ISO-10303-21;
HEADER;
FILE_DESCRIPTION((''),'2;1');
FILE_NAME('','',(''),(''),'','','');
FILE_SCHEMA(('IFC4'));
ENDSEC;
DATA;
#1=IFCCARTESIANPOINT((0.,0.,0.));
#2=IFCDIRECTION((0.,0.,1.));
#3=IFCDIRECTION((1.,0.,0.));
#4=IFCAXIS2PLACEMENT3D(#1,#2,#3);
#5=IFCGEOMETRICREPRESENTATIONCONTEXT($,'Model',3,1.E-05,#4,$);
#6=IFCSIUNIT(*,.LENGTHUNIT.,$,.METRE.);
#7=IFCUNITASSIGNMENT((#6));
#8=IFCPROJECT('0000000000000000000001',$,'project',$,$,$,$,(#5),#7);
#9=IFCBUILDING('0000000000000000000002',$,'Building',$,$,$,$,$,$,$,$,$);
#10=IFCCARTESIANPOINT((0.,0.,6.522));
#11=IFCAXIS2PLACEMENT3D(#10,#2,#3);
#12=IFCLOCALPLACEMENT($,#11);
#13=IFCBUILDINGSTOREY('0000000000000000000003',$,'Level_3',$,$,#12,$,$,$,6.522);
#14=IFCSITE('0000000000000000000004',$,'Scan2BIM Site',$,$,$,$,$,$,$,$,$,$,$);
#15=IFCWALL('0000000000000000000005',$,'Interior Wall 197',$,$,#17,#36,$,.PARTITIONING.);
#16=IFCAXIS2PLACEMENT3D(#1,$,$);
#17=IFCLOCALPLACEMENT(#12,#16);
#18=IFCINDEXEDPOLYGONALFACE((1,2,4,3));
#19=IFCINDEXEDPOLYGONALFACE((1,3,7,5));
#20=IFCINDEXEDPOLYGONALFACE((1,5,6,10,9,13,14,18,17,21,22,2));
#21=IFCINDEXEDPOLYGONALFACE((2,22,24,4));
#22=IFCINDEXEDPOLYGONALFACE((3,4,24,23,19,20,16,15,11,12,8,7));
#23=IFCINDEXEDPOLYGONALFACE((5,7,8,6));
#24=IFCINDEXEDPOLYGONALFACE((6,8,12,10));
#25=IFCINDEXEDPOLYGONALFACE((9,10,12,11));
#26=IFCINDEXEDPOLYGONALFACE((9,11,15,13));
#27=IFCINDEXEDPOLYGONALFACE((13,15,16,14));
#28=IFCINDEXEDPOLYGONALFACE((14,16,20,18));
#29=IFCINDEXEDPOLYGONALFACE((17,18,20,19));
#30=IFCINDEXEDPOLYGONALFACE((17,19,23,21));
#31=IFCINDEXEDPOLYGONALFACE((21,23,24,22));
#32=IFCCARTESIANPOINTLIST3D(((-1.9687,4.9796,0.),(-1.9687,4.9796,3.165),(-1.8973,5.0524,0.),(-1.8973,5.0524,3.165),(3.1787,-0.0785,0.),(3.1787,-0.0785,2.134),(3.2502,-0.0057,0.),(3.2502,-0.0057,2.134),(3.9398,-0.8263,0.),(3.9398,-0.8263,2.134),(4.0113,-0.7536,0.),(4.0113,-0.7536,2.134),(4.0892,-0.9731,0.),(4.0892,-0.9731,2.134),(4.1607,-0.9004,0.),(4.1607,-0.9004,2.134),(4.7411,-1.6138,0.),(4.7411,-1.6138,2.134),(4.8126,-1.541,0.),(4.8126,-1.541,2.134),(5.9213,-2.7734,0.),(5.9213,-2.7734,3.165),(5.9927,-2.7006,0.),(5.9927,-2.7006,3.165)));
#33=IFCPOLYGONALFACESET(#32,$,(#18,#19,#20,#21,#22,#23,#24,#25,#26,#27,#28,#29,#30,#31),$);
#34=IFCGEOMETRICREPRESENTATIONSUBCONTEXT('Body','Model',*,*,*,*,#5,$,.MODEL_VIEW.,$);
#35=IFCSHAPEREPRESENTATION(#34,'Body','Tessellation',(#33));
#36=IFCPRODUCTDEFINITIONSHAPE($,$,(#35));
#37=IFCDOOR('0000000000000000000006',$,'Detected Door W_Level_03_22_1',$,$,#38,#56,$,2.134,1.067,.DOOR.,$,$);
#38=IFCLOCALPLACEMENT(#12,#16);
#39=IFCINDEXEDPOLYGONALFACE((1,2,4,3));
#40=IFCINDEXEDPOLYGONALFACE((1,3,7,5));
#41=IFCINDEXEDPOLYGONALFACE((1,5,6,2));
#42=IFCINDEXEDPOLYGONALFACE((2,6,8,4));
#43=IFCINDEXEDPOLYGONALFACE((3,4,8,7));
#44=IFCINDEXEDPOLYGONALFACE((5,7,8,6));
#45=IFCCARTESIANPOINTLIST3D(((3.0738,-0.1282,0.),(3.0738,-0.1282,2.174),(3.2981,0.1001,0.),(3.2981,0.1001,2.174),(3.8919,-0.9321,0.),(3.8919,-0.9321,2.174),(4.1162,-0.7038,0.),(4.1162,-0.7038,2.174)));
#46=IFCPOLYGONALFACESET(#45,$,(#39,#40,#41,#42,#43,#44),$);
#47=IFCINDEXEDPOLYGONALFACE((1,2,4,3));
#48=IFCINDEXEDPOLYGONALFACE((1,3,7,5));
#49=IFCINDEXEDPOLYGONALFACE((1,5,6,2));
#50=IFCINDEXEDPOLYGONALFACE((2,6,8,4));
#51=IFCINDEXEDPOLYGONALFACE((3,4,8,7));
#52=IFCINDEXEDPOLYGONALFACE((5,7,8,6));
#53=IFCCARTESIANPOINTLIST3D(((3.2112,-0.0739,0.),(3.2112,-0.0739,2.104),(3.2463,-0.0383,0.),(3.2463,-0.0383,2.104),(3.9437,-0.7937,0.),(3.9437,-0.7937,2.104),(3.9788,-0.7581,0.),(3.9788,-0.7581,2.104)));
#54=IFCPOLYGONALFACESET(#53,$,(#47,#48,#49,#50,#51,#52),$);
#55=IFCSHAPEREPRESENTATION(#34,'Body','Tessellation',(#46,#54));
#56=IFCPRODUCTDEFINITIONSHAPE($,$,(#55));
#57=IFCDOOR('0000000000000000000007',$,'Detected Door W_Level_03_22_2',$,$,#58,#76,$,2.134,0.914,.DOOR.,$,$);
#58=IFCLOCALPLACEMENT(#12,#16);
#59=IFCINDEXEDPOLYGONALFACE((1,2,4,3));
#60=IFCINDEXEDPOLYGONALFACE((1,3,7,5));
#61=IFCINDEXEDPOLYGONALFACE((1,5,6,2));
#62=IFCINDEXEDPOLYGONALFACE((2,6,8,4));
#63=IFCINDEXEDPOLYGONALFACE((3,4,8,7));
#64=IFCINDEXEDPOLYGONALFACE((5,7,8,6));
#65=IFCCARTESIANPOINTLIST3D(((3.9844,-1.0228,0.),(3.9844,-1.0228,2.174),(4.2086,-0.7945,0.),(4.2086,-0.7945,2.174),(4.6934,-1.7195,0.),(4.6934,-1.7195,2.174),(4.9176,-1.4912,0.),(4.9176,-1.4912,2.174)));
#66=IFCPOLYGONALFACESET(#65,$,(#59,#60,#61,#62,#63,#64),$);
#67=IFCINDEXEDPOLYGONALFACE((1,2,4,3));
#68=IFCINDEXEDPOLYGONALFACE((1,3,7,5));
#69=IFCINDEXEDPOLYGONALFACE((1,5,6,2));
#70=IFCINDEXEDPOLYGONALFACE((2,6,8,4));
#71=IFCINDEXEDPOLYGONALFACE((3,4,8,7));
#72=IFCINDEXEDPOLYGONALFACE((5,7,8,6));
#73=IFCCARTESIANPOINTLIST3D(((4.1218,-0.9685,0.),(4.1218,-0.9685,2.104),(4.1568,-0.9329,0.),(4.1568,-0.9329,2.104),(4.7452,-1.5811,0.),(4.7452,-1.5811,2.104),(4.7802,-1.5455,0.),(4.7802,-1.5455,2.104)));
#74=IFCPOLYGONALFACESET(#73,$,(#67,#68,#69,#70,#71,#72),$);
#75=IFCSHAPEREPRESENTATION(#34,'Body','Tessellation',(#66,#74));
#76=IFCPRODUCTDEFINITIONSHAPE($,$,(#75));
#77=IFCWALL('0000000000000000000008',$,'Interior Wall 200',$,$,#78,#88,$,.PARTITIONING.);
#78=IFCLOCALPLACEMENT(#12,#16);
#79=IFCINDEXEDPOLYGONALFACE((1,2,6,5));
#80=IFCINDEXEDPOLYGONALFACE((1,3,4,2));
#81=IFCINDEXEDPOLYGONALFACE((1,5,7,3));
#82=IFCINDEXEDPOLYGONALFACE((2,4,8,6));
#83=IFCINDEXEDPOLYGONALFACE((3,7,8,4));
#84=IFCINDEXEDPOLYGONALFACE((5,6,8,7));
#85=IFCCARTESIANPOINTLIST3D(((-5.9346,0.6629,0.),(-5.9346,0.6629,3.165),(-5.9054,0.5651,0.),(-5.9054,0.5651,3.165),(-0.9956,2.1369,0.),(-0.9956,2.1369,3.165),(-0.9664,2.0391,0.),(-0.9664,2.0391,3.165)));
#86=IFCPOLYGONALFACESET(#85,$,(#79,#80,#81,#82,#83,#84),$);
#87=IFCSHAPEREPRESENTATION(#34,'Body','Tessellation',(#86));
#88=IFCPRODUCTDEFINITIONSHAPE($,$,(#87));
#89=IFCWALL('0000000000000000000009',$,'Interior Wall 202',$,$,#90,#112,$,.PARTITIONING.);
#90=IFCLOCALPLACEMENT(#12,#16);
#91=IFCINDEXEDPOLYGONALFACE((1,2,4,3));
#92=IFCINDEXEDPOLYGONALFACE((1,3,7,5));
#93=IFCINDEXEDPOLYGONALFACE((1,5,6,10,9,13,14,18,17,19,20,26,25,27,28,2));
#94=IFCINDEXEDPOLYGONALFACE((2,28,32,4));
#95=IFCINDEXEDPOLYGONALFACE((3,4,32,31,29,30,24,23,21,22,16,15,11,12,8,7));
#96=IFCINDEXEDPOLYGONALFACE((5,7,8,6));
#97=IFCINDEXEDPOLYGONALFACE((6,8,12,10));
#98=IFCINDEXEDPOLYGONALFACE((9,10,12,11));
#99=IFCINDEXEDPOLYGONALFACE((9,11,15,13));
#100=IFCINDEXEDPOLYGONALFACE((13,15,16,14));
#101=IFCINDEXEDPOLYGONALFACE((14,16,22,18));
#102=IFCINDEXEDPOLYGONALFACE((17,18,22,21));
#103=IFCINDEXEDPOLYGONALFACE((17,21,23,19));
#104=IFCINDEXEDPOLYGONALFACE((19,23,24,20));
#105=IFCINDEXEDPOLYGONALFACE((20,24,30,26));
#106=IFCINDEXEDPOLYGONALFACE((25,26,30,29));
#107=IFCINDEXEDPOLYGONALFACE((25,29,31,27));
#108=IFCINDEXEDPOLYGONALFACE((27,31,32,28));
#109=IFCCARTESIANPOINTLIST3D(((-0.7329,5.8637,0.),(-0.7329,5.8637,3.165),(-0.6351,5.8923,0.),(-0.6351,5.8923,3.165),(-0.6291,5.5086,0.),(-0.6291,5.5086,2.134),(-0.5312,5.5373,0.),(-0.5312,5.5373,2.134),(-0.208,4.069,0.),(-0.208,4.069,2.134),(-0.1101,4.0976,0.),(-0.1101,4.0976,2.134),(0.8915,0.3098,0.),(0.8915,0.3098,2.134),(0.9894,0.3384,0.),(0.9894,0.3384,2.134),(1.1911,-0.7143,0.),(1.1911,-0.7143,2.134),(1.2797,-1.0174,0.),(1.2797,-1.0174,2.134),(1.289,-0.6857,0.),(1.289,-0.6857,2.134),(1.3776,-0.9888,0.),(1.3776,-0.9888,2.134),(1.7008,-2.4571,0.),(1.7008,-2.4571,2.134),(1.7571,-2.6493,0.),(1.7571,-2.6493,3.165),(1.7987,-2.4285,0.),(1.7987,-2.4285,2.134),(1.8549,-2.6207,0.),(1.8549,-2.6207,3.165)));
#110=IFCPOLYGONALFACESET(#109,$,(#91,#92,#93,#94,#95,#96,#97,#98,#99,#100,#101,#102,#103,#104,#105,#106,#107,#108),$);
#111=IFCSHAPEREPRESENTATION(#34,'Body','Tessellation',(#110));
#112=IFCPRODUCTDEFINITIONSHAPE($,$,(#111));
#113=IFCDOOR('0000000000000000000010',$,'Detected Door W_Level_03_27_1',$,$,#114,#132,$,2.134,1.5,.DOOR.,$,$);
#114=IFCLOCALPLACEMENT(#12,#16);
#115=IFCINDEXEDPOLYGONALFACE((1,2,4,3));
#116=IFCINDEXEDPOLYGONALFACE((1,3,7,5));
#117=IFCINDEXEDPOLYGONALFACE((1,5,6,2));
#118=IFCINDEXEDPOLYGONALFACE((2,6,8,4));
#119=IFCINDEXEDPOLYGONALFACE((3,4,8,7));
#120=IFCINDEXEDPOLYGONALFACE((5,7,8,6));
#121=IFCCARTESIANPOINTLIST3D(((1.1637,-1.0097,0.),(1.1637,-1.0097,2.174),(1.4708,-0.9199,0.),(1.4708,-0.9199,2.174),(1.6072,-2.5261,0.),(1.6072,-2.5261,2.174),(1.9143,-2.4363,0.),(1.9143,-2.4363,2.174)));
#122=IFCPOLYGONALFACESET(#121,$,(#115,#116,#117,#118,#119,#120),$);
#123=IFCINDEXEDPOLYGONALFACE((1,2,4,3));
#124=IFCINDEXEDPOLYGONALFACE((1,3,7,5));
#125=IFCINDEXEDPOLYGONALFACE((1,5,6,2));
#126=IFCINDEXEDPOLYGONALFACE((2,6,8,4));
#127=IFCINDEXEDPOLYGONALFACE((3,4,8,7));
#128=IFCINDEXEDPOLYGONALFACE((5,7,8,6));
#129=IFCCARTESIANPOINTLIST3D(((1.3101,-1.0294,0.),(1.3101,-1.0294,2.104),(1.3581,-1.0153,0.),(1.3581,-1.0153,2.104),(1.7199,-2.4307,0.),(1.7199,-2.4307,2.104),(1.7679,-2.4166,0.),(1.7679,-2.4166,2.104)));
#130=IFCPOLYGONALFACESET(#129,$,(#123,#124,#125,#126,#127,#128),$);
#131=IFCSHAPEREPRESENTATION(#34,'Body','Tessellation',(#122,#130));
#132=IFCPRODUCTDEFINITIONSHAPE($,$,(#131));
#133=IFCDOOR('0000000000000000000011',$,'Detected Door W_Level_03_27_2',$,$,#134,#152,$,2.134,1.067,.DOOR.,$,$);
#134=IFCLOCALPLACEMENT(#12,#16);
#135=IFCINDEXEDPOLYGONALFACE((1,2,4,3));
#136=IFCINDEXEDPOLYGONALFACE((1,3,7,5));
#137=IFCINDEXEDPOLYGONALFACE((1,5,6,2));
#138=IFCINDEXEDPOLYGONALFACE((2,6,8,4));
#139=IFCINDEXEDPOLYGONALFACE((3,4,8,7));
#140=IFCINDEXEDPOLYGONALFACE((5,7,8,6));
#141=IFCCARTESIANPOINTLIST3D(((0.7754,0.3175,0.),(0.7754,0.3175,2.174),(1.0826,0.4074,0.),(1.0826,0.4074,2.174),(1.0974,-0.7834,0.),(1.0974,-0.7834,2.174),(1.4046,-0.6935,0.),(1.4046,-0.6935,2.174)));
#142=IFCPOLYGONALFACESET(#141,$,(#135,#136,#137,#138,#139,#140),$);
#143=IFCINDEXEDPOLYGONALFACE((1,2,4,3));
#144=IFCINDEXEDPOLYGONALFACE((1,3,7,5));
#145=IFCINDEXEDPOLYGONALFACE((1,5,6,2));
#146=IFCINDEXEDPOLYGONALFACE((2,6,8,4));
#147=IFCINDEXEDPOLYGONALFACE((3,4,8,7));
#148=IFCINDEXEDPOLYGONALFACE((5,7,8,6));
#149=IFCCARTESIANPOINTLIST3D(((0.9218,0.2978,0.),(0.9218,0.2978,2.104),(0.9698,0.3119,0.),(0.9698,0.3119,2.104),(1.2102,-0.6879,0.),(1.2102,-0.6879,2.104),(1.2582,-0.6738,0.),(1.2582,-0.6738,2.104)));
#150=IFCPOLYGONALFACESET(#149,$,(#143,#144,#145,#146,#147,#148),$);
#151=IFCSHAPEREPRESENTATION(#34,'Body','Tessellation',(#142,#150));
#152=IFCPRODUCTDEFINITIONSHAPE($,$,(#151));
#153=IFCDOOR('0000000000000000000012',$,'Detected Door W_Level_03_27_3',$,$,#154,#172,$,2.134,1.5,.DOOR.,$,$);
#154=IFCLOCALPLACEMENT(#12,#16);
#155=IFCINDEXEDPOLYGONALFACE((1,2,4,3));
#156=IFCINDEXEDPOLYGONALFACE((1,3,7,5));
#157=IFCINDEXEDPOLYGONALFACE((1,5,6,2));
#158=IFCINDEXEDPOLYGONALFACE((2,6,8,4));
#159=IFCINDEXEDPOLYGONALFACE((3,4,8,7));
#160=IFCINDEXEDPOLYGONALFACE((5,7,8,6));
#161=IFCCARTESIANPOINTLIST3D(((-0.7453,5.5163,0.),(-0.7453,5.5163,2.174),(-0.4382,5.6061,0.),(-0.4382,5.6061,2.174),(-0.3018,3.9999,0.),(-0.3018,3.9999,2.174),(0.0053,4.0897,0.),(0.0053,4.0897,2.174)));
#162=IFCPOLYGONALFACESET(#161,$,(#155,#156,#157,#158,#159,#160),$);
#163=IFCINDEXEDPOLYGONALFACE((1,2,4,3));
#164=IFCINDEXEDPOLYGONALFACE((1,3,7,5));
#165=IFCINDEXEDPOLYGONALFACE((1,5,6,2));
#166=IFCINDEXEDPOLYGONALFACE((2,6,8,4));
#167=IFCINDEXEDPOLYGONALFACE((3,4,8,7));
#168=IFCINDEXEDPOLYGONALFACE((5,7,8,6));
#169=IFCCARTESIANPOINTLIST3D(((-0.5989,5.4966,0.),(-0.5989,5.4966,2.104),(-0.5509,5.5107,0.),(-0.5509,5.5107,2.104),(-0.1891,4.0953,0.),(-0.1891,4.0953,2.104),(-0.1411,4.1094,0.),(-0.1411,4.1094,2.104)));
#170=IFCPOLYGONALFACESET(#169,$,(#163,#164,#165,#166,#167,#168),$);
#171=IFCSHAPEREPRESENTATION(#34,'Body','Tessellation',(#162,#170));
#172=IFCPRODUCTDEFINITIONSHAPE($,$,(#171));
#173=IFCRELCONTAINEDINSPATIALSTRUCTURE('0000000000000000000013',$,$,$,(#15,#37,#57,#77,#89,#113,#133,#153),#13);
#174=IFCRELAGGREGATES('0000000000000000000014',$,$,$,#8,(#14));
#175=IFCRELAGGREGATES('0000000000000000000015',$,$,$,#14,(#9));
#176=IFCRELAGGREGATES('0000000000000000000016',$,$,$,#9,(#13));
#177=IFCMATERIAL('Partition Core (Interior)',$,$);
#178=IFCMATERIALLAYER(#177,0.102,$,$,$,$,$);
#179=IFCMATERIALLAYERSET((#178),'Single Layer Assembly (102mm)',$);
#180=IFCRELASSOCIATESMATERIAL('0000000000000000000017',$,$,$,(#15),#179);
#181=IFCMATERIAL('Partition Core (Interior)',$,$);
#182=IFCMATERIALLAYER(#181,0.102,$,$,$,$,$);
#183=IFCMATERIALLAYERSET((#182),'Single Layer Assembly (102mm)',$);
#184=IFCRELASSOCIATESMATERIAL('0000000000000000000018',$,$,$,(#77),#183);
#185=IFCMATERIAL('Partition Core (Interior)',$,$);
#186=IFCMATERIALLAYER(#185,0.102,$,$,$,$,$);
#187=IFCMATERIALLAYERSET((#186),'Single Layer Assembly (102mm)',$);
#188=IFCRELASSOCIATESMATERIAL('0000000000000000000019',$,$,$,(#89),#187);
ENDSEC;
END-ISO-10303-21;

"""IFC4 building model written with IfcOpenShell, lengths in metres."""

from ifc_helpers import new_model, si_unit, frame, origin, origin_with_axes, place, context, subcontext, project, spatial, rectangle, extrude, material, layer, layer_set, element, fill, save


model = new_model("IFC4")

# Units and contexts
model_context = context("Model", 3, precision=1e-05, world=origin_with_axes())
body_context = subcontext(model_context, "Body", "Model", "MODEL_VIEW")
ifc_project = project(units=[si_unit("LENGTHUNIT", "METRE")], contexts=[model_context])

# Site, building, storey
site = spatial("IfcSite", under=ifc_project, Name="Scan2BIM Site")
building = spatial("IfcBuilding", under=site, Name="Building")
storey_placement = place(None, frame((0.0, 0.0, 6.522), z_axis=(0.0, 0.0, 1.0), x_axis=(1.0, 0.0, 0.0)))
storey = spatial("IfcBuildingStorey", under=building, at=storey_placement, Name="Level_3", Elevation=6.522)

# Wall, openings, doors
ifc_material_1 = material(Name="Partition Core (Interior)")
ifc_layer_1 = layer(ifc_material_1, 0.102)
ifc_layer_set_1 = layer_set([ifc_layer_1], Name="Single Layer Assembly (102mm)")
wall_1_placement = place(storey_placement, frame((2.012, 1.1395, 0.0), z_axis=(0.0, 0.0, 1.0), x_axis=(0.713272, -0.700887, 0.0)))
wall_1 = element("IfcWall", 1, at=wall_1_placement, inside=storey, material=ifc_layer_set_1, Name="Interior Wall 197", PredefinedType="PARTITIONING", context=body_context, shape_type="SweptSolid", body=[
    extrude(rectangle(XDim=11.0617, YDim=0.102), origin(), (0.0, 0.0, 1.0), 3.165),
])
opening_1_placement = place(None, frame((3.595, -0.416, 6.522), z_axis=(0.0, 0.0, 1.0), x_axis=(0.713272, -0.700887, 0.0)))
opening_1 = element("IfcOpeningElement", 2, at=opening_1_placement, cuts=wall_1, PredefinedType="OPENING", context=body_context, shape_type="SweptSolid", body=[
    extrude(rectangle(XDim=1.067, YDim=0.202), origin(), (0.0, 0.0, 1.0), 2.134),
])
opening_2_placement = place(None, frame((4.451, -1.257, 6.522), z_axis=(0.0, 0.0, 1.0), x_axis=(0.713272, -0.700887, 0.0)))
opening_2 = element("IfcOpeningElement", 3, at=opening_2_placement, cuts=wall_1, PredefinedType="OPENING", context=body_context, shape_type="SweptSolid", body=[
    extrude(rectangle(XDim=0.914, YDim=0.202), origin(), (0.0, 0.0, 1.0), 2.134),
])
door_1_placement = place(opening_1_placement, frame((0.0, 0.0, 0.0), z_axis=(0.0, 0.0, 1.0), x_axis=(1.0, 0.0, 0.0)))
door_1 = element("IfcDoor", 4, at=door_1_placement, inside=storey, Name="Detected Door W_Level_03_22_1", OverallHeight=2.134, OverallWidth=1.067, PredefinedType="DOOR", context=body_context, shape_type="SweptSolid", body=[
    extrude(rectangle(XDim=1.147, YDim=0.32), origin(), (0.0, 0.0, 1.0), 2.174),
    extrude(rectangle(XDim=1.027, YDim=0.05), origin(), (0.0, 0.0, 1.0), 2.104),
])
fill(opening_1, door_1)
door_2_placement = place(opening_2_placement, frame((0.0, 0.0, 0.0), z_axis=(0.0, 0.0, 1.0), x_axis=(1.0, 0.0, 0.0)))
door_2 = element("IfcDoor", 5, at=door_2_placement, inside=storey, Name="Detected Door W_Level_03_22_2", OverallHeight=2.134, OverallWidth=0.914, PredefinedType="DOOR", context=body_context, shape_type="SweptSolid", body=[
    extrude(rectangle(XDim=0.994, YDim=0.32), origin(), (0.0, 0.0, 1.0), 2.174),
    extrude(rectangle(XDim=0.874, YDim=0.05), origin(), (0.0, 0.0, 1.0), 2.104),
])
fill(opening_2, door_2)

# Wall
ifc_material_2 = material(Name="Partition Core (Interior)")
ifc_layer_2 = layer(ifc_material_2, 0.102)
ifc_layer_set_2 = layer_set([ifc_layer_2], Name="Single Layer Assembly (102mm)")
wall_2_placement = place(storey_placement, frame((-3.4505, 1.351, 0.0), z_axis=(0.0, 0.0, 1.0), x_axis=(-0.958236, -0.285977, 0.0)))
element("IfcWall", 6, at=wall_2_placement, inside=storey, material=ifc_layer_set_2, Name="Interior Wall 200", PredefinedType="PARTITIONING", context=body_context, shape_type="SweptSolid", body=[
    extrude(rectangle(XDim=5.1543, YDim=0.102), origin(), (0.0, 0.0, 1.0), 3.165),
])

# Wall, openings, doors
ifc_material_3 = material(Name="Partition Core (Interior)")
ifc_layer_3 = layer(ifc_material_3, 0.102)
ifc_layer_set_3 = layer_set([ifc_layer_3], Name="Single Layer Assembly (102mm)")
wall_3_placement = place(storey_placement, frame((0.561, 1.6215, 0.0), z_axis=(0.0, 0.0, 1.0), x_axis=(-0.280732, 0.959786, 0.0)))
wall_3 = element("IfcWall", 7, at=wall_3_placement, inside=storey, material=ifc_layer_set_3, Name="Interior Wall 202", PredefinedType="PARTITIONING", context=body_context, shape_type="SweptSolid", body=[
    extrude(rectangle(XDim=8.8697, YDim=0.102), origin(), (0.0, 0.0, 1.0), 3.165),
])
opening_3_placement = place(None, frame((1.539, -1.723, 6.522), z_axis=(0.0, 0.0, 1.0), x_axis=(-0.280732, 0.959786, 0.0)))
opening_3 = element("IfcOpeningElement", 8, at=opening_3_placement, cuts=wall_3, PredefinedType="OPENING", context=body_context, shape_type="SweptSolid", body=[
    extrude(rectangle(XDim=1.5, YDim=0.202), origin(), (0.0, 0.0, 1.0), 2.134),
])
opening_4_placement = place(None, frame((1.09, -0.188, 6.522), z_axis=(0.0, 0.0, 1.0), x_axis=(-0.280732, 0.959786, 0.0)))
opening_4 = element("IfcOpeningElement", 9, at=opening_4_placement, cuts=wall_3, PredefinedType="OPENING", context=body_context, shape_type="SweptSolid", body=[
    extrude(rectangle(XDim=1.067, YDim=0.202), origin(), (0.0, 0.0, 1.0), 2.134),
])
opening_5_placement = place(None, frame((-0.37, 4.803, 6.522), z_axis=(0.0, 0.0, 1.0), x_axis=(-0.280732, 0.959786, 0.0)))
opening_5 = element("IfcOpeningElement", 10, at=opening_5_placement, cuts=wall_3, PredefinedType="OPENING", context=body_context, shape_type="SweptSolid", body=[
    extrude(rectangle(XDim=1.5, YDim=0.202), origin(), (0.0, 0.0, 1.0), 2.134),
])
door_3_placement = place(opening_3_placement, frame((0.0, 0.0, 0.0), z_axis=(0.0, 0.0, 1.0), x_axis=(1.0, 0.0, 0.0)))
door_3 = element("IfcDoor", 11, at=door_3_placement, inside=storey, Name="Detected Door W_Level_03_27_1", OverallHeight=2.134, OverallWidth=1.5, PredefinedType="DOOR", context=body_context, shape_type="SweptSolid", body=[
    extrude(rectangle(XDim=1.58, YDim=0.32), origin(), (0.0, 0.0, 1.0), 2.174),
    extrude(rectangle(XDim=1.46, YDim=0.05), origin(), (0.0, 0.0, 1.0), 2.104),
])
fill(opening_3, door_3)
door_4_placement = place(opening_4_placement, frame((0.0, 0.0, 0.0), z_axis=(0.0, 0.0, 1.0), x_axis=(1.0, 0.0, 0.0)))
door_4 = element("IfcDoor", 12, at=door_4_placement, inside=storey, Name="Detected Door W_Level_03_27_2", OverallHeight=2.134, OverallWidth=1.067, PredefinedType="DOOR", context=body_context, shape_type="SweptSolid", body=[
    extrude(rectangle(XDim=1.147, YDim=0.32), origin(), (0.0, 0.0, 1.0), 2.174),
    extrude(rectangle(XDim=1.027, YDim=0.05), origin(), (0.0, 0.0, 1.0), 2.104),
])
fill(opening_4, door_4)
door_5_placement = place(opening_5_placement, frame((0.0, 0.0, 0.0), z_axis=(0.0, 0.0, 1.0), x_axis=(1.0, 0.0, 0.0)))
door_5 = element("IfcDoor", 13, at=door_5_placement, inside=storey, Name="Detected Door W_Level_03_27_3", OverallHeight=2.134, OverallWidth=1.5, PredefinedType="DOOR", context=body_context, shape_type="SweptSolid", body=[
    extrude(rectangle(XDim=1.58, YDim=0.32), origin(), (0.0, 0.0, 1.0), 2.174),
    extrude(rectangle(XDim=1.46, YDim=0.05), origin(), (0.0, 0.0, 1.0), 2.104),
])
fill(opening_5, door_5)

save(model, "model.ifc")
